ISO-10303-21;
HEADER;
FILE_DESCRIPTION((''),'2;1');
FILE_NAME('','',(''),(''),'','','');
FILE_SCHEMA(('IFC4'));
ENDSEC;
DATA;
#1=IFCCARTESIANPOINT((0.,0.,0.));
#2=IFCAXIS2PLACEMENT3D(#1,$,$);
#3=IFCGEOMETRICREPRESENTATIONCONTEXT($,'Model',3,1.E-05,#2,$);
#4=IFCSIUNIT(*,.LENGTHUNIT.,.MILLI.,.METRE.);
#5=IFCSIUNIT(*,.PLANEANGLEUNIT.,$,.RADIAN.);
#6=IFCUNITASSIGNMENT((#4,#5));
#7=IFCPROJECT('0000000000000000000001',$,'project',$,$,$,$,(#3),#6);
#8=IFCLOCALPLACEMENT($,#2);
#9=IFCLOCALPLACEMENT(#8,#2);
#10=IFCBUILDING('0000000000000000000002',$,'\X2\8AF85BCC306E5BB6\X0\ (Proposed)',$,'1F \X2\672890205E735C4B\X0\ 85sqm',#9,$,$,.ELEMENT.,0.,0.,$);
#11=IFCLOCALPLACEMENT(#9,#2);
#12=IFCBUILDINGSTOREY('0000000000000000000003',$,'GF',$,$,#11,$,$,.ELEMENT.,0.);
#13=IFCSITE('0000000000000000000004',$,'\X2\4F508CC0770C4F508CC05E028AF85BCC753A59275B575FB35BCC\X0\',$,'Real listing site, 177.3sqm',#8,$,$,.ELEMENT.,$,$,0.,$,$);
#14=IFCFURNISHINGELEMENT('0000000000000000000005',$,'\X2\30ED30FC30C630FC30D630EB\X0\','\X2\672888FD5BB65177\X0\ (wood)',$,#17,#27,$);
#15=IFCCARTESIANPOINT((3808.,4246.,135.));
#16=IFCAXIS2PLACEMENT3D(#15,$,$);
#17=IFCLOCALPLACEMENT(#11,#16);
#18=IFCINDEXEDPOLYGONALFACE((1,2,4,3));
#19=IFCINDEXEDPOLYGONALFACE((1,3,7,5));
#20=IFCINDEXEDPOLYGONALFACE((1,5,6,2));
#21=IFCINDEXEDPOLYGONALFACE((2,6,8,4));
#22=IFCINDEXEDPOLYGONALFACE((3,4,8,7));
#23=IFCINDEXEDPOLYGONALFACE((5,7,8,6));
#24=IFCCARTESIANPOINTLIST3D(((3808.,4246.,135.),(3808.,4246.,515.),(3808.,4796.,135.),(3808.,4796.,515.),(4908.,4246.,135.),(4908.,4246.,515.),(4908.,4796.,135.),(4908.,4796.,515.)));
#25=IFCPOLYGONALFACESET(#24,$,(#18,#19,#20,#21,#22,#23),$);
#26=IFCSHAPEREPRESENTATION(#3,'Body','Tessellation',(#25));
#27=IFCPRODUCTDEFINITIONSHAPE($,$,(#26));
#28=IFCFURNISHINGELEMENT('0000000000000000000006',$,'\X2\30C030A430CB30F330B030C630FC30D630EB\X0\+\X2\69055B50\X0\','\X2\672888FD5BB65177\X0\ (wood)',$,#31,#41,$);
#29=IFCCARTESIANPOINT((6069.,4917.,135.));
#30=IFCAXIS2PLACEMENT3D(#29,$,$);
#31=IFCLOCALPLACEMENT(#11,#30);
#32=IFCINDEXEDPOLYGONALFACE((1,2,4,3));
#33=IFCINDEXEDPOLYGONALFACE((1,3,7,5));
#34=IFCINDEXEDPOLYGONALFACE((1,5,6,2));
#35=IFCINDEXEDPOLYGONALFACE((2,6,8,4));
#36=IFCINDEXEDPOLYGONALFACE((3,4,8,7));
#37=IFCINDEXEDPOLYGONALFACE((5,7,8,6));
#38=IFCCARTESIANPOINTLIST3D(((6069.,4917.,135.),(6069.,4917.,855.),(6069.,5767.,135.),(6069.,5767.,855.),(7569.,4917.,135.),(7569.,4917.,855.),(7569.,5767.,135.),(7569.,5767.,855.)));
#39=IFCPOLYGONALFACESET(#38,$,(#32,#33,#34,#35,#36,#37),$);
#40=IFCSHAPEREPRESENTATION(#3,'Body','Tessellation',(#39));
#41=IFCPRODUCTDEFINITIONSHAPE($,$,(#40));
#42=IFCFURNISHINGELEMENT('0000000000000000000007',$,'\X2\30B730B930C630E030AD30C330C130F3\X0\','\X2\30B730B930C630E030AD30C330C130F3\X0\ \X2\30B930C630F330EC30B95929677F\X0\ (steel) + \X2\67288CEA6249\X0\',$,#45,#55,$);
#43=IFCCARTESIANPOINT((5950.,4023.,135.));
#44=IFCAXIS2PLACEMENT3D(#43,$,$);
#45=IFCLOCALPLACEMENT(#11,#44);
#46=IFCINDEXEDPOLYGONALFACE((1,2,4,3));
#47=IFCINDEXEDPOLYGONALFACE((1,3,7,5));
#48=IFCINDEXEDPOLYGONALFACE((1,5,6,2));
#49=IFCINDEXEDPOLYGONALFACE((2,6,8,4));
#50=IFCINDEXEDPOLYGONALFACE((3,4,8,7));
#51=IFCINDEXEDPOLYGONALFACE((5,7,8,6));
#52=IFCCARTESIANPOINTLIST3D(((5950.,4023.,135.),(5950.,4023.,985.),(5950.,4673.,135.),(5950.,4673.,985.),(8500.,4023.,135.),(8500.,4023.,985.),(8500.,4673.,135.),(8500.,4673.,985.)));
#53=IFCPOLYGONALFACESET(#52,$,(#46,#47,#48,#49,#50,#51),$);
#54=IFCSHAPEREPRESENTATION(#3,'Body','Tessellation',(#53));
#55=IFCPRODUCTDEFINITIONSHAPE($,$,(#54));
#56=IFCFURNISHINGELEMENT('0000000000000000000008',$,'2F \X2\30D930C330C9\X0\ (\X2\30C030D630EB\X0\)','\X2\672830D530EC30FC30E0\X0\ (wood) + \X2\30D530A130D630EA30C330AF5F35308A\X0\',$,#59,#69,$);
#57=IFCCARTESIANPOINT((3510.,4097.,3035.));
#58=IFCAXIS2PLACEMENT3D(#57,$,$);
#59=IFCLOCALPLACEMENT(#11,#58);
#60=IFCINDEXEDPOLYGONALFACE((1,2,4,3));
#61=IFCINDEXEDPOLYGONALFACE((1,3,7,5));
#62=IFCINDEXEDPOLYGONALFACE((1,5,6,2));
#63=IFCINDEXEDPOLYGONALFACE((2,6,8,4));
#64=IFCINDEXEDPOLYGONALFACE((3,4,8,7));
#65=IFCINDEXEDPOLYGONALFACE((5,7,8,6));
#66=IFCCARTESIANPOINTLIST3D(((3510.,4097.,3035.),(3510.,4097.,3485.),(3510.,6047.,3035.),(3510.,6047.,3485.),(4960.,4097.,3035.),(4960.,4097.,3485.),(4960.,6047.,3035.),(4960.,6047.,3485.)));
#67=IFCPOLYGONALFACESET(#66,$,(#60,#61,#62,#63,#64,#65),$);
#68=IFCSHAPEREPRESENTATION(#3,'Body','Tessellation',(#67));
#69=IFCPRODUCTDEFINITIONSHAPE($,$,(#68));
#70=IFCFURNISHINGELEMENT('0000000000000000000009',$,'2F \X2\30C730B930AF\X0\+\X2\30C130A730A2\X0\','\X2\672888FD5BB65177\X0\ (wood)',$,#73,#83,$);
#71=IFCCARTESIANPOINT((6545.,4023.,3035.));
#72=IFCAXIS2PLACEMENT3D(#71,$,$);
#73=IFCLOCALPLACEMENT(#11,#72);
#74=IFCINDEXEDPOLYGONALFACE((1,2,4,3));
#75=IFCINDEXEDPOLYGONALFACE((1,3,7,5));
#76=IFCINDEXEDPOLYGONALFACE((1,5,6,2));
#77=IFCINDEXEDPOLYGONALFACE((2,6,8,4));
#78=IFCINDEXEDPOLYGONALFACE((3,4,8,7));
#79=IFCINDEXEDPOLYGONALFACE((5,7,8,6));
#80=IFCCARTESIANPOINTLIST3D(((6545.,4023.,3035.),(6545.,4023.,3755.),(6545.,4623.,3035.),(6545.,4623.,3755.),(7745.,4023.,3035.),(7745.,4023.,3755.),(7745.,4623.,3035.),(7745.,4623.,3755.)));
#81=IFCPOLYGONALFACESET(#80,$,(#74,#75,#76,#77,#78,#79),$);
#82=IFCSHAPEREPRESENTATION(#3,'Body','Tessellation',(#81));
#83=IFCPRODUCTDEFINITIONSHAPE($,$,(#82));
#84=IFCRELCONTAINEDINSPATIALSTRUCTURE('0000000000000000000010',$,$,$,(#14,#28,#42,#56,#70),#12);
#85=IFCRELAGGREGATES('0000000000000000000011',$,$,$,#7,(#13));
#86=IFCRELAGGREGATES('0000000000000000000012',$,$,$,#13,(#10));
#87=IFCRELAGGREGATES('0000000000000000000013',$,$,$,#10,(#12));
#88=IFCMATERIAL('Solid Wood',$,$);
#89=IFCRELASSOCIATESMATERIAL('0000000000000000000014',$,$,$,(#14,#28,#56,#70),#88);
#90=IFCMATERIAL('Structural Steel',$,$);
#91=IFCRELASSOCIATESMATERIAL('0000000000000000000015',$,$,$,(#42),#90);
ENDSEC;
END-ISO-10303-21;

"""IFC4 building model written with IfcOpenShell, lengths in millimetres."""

from ifc_helpers import new_model, si_unit, frame, frame_2d, origin, place, context, project, spatial, rectangle, extrude, material, element, save


model = new_model("IFC4")

# Units and contexts
model_context = context("Model", 3, precision=1e-05, world=origin())
ifc_project = project(units=[si_unit("LENGTHUNIT", "METRE", prefix="MILLI"), si_unit("PLANEANGLEUNIT", "RADIAN")], contexts=[model_context])

# Site, building, storey
site_placement = place(None, origin())
site = spatial("IfcSite", under=ifc_project, at=site_placement, Name="佐賀県佐賀市諸富町大字徳富", ObjectType="Real listing site, 177.3sqm", CompositionType="ELEMENT", RefElevation=0.0)
building_placement = place(site_placement, origin())
building = spatial("IfcBuilding", under=site, at=building_placement, Name="諸富の家 (Proposed)", ObjectType="1F 木造平屋 85sqm", CompositionType="ELEMENT", ElevationOfRefHeight=0.0, ElevationOfTerrain=0.0)
storey_placement = place(building_placement, origin())
storey = spatial("IfcBuildingStorey", under=building, at=storey_placement, Name="GF", CompositionType="ELEMENT", Elevation=0.0)

# Shared definitions
ifc_material_1 = material(Name="Solid Wood")

# Shared definitions
ifc_material_2 = material(Name="Structural Steel")

# Furnishing elements
furnishing_1_placement = place(storey_placement, frame((3808.0, 4246.0, 135.0)))
element("IfcFurnishingElement", 1, at=furnishing_1_placement, inside=storey, material=ifc_material_1, Name="ローテーブル", Description="木製家具 (wood)", context=model_context, shape_type="SweptSolid", body=[
    extrude(rectangle(XDim=1100.0, YDim=550.0, at=frame_2d((550.0, 275.0))), frame((3808.0, 4246.0, 135.0)), (0.0, 0.0, 1.0), 380.0),
])
furnishing_2_placement = place(storey_placement, frame((6069.0, 4917.0, 135.0)))
element("IfcFurnishingElement", 2, at=furnishing_2_placement, inside=storey, material=ifc_material_1, Name="ダイニングテーブル+椅子", Description="木製家具 (wood)", context=model_context, shape_type="SweptSolid", body=[
    extrude(rectangle(XDim=1500.0, YDim=850.0, at=frame_2d((750.0, 425.0))), frame((6069.0, 4917.0, 135.0)), (0.0, 0.0, 1.0), 720.0),
])
furnishing_3_placement = place(storey_placement, frame((5950.0, 4023.0, 135.0)))
element("IfcFurnishingElement", 3, at=furnishing_3_placement, inside=storey, material=ifc_material_2, Name="システムキッチン", Description="システムキッチン ステンレス天板 (steel) + 木質扉", context=model_context, shape_type="SweptSolid", body=[
    extrude(rectangle(XDim=2550.0, YDim=650.0, at=frame_2d((1275.0, 325.0))), frame((5950.0, 4023.0, 135.0)), (0.0, 0.0, 1.0), 850.0),
])
furnishing_4_placement = place(storey_placement, frame((3510.0, 4097.0, 3035.0)))
element("IfcFurnishingElement", 4, at=furnishing_4_placement, inside=storey, material=ifc_material_1, Name="2F ベッド (ダブル)", Description="木フレーム (wood) + ファブリック張り", context=model_context, shape_type="SweptSolid", body=[
    extrude(rectangle(XDim=1450.0, YDim=1950.0, at=frame_2d((725.0, 975.0))), frame((3510.0, 4097.0, 3035.0)), (0.0, 0.0, 1.0), 450.0),
])
furnishing_5_placement = place(storey_placement, frame((6545.0, 4023.0, 3035.0)))
element("IfcFurnishingElement", 5, at=furnishing_5_placement, inside=storey, material=ifc_material_1, Name="2F デスク+チェア", Description="木製家具 (wood)", context=model_context, shape_type="SweptSolid", body=[
    extrude(rectangle(XDim=1200.0, YDim=600.0, at=frame_2d((600.0, 300.0))), frame((6545.0, 4023.0, 3035.0)), (0.0, 0.0, 1.0), 720.0),
])

save(model, "model.ifc")
